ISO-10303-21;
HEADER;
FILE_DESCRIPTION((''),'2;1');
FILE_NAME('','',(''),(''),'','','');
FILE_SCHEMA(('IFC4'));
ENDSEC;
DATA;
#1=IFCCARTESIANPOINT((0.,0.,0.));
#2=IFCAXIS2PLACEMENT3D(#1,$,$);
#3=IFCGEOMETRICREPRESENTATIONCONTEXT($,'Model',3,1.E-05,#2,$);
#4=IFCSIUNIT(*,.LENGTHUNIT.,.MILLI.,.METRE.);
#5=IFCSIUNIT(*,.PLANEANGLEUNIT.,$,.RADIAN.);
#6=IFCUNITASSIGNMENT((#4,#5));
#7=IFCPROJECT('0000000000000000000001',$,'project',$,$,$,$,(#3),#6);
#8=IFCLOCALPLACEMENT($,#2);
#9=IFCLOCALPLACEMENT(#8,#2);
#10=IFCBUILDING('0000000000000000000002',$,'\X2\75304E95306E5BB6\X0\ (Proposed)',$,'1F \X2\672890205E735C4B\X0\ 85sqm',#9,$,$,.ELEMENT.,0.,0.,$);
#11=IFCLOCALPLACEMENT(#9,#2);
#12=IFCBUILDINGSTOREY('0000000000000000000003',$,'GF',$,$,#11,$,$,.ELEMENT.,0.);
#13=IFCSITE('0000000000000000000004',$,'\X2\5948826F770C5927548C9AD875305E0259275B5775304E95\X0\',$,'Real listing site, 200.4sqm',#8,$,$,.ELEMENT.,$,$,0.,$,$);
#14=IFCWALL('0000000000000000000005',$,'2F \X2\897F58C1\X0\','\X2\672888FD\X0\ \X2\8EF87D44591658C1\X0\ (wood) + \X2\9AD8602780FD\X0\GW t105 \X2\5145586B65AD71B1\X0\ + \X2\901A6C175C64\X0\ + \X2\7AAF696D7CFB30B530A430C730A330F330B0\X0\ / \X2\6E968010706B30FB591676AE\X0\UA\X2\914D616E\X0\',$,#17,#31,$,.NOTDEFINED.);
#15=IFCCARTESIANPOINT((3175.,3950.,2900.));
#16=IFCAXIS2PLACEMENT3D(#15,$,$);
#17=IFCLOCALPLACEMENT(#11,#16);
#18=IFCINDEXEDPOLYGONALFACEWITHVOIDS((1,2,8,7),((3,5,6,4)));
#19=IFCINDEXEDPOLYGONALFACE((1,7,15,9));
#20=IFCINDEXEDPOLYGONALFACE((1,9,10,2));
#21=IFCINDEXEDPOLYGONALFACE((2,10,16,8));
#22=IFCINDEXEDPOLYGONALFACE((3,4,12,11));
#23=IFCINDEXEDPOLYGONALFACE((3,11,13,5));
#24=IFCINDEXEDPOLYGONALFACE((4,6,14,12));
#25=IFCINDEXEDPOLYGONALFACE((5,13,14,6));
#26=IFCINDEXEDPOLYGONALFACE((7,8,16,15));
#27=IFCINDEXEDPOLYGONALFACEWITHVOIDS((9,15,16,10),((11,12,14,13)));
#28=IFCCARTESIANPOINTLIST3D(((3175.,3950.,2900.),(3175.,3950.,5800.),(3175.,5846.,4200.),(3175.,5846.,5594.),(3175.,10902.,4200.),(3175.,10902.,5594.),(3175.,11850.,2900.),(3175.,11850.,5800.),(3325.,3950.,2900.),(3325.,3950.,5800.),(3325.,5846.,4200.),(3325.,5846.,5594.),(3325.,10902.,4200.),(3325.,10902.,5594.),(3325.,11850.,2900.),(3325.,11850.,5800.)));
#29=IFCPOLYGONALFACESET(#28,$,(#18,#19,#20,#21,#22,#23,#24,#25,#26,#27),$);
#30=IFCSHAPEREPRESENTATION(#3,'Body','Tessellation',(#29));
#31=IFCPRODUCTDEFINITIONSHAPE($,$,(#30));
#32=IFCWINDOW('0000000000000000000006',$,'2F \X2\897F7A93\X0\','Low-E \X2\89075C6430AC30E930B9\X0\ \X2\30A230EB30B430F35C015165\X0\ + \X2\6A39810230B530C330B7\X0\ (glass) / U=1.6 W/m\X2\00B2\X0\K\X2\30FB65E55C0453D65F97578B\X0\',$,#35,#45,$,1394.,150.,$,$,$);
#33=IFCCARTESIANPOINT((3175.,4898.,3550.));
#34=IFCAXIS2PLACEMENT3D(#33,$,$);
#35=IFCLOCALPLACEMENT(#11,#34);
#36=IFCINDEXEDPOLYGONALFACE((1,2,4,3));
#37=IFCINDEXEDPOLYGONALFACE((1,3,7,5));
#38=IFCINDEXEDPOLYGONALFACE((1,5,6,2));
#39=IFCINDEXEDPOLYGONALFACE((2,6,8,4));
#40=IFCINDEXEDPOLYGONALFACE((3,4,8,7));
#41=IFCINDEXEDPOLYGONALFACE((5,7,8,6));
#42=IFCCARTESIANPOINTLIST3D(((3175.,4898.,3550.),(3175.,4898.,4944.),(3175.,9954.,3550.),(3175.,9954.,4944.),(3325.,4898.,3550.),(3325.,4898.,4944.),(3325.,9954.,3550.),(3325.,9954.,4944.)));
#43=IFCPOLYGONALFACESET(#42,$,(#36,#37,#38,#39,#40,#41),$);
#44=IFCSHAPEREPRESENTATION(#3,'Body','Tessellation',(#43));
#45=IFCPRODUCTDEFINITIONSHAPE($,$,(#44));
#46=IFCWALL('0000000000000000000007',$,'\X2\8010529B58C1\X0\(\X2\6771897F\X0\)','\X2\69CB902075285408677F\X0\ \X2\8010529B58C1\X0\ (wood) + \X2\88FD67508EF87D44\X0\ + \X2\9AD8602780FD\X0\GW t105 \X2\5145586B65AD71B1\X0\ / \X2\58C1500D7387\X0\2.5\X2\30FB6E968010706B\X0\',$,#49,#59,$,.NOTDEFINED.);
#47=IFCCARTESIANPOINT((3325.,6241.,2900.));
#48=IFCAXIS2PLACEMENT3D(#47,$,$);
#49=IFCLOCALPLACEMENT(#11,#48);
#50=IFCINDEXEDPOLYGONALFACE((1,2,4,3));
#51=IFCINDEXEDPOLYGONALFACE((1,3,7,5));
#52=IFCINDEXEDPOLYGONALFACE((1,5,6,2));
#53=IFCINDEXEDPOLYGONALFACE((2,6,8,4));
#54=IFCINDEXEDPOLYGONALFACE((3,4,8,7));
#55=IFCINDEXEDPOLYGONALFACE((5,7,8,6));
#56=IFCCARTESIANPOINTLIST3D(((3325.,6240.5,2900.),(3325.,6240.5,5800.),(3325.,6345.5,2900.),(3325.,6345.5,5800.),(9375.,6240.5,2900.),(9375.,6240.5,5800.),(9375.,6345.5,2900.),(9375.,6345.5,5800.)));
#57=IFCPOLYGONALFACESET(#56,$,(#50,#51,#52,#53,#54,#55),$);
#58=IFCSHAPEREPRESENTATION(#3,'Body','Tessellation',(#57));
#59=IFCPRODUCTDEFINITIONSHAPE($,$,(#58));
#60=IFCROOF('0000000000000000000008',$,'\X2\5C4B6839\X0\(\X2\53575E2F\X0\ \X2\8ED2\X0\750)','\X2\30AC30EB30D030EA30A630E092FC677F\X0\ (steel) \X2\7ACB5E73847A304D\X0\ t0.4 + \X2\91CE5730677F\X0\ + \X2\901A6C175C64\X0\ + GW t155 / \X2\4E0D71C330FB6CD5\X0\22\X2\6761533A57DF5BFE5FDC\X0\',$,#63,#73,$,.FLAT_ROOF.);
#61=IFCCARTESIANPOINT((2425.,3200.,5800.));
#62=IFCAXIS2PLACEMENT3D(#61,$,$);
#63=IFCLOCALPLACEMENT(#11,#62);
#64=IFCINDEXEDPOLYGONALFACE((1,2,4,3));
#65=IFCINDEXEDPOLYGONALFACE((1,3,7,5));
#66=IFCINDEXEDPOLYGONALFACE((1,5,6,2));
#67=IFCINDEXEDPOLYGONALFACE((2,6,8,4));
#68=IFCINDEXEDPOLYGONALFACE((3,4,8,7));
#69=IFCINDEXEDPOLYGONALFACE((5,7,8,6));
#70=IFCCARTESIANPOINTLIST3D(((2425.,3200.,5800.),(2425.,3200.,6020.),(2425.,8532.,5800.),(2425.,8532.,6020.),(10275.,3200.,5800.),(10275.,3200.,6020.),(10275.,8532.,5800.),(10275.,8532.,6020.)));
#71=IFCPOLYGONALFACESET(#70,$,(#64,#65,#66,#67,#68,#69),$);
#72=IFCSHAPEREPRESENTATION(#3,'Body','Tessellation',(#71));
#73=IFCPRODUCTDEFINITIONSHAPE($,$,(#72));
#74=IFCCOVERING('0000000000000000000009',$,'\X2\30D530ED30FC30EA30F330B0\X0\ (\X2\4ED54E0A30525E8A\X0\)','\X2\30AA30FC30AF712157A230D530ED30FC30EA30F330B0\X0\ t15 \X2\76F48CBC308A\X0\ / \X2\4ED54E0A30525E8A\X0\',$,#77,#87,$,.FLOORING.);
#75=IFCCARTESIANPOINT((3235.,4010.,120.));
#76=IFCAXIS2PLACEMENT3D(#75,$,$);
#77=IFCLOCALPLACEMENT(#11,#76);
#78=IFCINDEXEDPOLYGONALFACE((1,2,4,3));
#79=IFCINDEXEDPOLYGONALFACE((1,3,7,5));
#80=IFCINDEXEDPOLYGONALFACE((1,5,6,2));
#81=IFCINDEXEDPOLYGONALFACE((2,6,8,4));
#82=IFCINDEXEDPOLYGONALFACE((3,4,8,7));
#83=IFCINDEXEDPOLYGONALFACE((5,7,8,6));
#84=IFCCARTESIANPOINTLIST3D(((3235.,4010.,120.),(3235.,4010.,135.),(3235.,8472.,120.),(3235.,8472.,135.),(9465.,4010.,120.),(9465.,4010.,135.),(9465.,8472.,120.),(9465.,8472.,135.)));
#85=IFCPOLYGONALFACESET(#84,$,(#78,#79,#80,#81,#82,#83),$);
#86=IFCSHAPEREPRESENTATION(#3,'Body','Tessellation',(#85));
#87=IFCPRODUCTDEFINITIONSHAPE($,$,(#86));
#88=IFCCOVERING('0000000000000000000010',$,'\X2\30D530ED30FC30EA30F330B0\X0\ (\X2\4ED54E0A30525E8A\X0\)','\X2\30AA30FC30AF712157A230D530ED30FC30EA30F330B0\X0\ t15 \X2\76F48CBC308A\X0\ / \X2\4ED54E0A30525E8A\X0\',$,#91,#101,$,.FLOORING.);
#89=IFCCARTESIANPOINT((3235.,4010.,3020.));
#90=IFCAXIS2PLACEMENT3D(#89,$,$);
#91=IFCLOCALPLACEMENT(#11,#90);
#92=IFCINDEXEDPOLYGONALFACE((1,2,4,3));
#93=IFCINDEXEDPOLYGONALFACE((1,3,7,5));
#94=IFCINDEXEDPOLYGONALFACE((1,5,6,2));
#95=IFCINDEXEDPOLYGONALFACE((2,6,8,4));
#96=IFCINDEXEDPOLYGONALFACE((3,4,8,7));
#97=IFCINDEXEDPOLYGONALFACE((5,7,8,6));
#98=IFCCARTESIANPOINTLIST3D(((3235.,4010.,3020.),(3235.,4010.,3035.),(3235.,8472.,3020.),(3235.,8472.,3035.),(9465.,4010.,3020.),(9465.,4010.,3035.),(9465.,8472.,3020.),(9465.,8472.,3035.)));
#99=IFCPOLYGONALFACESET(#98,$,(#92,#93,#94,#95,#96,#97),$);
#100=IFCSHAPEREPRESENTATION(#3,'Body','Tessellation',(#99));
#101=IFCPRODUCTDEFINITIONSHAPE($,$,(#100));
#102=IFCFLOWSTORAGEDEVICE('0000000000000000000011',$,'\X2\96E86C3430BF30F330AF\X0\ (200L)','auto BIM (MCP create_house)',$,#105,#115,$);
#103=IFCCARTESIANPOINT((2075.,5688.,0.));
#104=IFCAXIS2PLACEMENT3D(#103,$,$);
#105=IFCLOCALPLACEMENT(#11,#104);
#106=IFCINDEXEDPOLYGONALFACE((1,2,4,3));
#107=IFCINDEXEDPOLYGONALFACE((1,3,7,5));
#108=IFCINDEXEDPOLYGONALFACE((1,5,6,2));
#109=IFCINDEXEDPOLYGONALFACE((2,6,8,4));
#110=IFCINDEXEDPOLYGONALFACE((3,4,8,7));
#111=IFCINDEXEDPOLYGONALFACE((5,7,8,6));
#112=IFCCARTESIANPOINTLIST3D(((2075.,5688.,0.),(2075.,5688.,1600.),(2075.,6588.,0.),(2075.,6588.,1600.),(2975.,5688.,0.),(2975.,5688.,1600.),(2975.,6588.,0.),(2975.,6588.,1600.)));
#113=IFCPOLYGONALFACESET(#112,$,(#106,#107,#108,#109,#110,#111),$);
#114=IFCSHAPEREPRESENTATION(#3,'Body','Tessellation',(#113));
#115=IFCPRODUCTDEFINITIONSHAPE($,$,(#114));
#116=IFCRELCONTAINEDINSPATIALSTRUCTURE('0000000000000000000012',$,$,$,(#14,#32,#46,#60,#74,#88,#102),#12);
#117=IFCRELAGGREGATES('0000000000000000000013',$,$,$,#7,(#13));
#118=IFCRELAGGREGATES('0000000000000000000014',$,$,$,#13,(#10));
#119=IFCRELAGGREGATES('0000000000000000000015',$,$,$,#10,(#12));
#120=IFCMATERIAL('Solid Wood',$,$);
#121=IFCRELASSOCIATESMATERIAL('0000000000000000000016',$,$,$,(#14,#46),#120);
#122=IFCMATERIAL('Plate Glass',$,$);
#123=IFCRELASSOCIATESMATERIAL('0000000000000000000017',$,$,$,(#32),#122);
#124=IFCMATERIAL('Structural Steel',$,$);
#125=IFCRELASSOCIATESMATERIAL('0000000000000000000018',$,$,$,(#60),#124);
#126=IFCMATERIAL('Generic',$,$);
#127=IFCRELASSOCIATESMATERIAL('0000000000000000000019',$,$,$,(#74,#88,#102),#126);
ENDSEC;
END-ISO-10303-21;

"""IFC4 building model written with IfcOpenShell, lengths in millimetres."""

from ifc_helpers import new_model, si_unit, frame, frame_2d, origin, place, context, project, spatial, rectangle, extrude, material, element, fill, save


model = new_model("IFC4")

# Units and contexts
model_context = context("Model", 3, precision=1e-05, world=origin())
ifc_project = project(units=[si_unit("LENGTHUNIT", "METRE", prefix="MILLI"), si_unit("PLANEANGLEUNIT", "RADIAN")], contexts=[model_context])

# Site, building, storey
site_placement = place(None, origin())
site = spatial("IfcSite", under=ifc_project, at=site_placement, Name="奈良県大和高田市大字田井", ObjectType="Real listing site, 200.4sqm", CompositionType="ELEMENT", RefElevation=0.0)
building_placement = place(site_placement, origin())
building = spatial("IfcBuilding", under=site, at=building_placement, Name="田井の家 (Proposed)", ObjectType="1F 木造平屋 85sqm", CompositionType="ELEMENT", ElevationOfRefHeight=0.0, ElevationOfTerrain=0.0)
storey_placement = place(building_placement, origin())
storey = spatial("IfcBuildingStorey", under=building, at=storey_placement, Name="GF", CompositionType="ELEMENT", Elevation=0.0)

# Shared definitions
ifc_material_1 = material(Name="Solid Wood")
ifc_material_2 = material(Name="Generic")

# Shared definitions
ifc_material_3 = material(Name="Plate Glass")

# Wall, opening, window
wall_1_placement = place(storey_placement, frame((3175.0, 3950.0, 2900.0)))
wall_1 = element("IfcWall", 1, at=wall_1_placement, inside=storey, material=ifc_material_1, Name="2F 西壁", Description="木製 軸組外壁 (wood) + 高性能GW t105 充填断熱 + 通気層 + 窯業系サイディング / 準耐火・外皮UA配慮", PredefinedType="NOTDEFINED", context=model_context, shape_type="SweptSolid", body=[
    extrude(rectangle(XDim=150.0, YDim=7900.0, at=frame_2d((75.0, 3950.0))), frame((3175.0, 3950.0, 2900.0)), (0.0, 0.0, 1.0), 2900.0),
])
opening_1_placement = place(storey_placement, frame((3175.0, 4898.0, 3550.0)))
opening_1 = element("IfcOpeningElement", 2, at=opening_1_placement, cuts=wall_1, PredefinedType="NOTDEFINED", context=model_context, shape_type="SweptSolid", body=[
    extrude(rectangle(XDim=150.0, YDim=5056.0, at=frame_2d((75.0, 2528.0))), frame((3175.0, 4898.0, 3550.0)), (0.0, 0.0, 1.0), 1394.0),
])
window_1_placement = place(storey_placement, frame((3175.0, 4898.0, 3550.0)))
window_1 = element("IfcWindow", 3, at=window_1_placement, inside=storey, material=ifc_material_3, Name="2F 西窓", Description="Low-E 複層ガラス アルゴン封入 + 樹脂サッシ (glass) / U=1.6 W/m²K・日射取得型", OverallHeight=1394.0, OverallWidth=150.0, context=model_context, shape_type="SweptSolid", body=[
    extrude(rectangle(XDim=150.0, YDim=5056.0, at=frame_2d((75.0, 2528.0))), frame((3175.0, 4898.0, 3550.0)), (0.0, 0.0, 1.0), 1394.0),
])
fill(opening_1, window_1)

# Wall
wall_2_placement = place(storey_placement, frame((3325.0, 6241.0, 2900.0)))
element("IfcWall", 4, at=wall_2_placement, inside=storey, material=ifc_material_1, Name="耐力壁(東西)", Description="構造用合板 耐力壁 (wood) + 製材軸組 + 高性能GW t105 充填断熱 / 壁倍率2.5・準耐火", PredefinedType="NOTDEFINED", context=model_context, shape_type="SweptSolid", body=[
    extrude(rectangle(XDim=6050.0, YDim=105.0, at=frame_2d((3025.0, 52.0))), frame((3325.0, 6241.0, 2900.0)), (0.0, 0.0, 1.0), 2900.0),
])

# Roof
ifc_material_4 = material(Name="Structural Steel")
for number, where, name in (
    (5, (2425.0, 3200.0, 5800.0), "屋根(南帯 軒750)"),
):
    element("IfcRoof", number, at=place(storey_placement, frame(where)), inside=storey, material=ifc_material_4, Name=name, Description="ガルバリウム鋼板 (steel) 立平葺き t0.4 + 野地板 + 通気層 + GW t155 / 不燃・法22条区域対応", PredefinedType="FLAT_ROOF", context=model_context, shape_type="SweptSolid", body=[
        extrude(rectangle(XDim=7850.0, YDim=5332.0, at=frame_2d((3925.0, 2666.0))), frame((2425.0, 3200.0, 5800.0)), (0.0, 0.0, 1.0), 220.0),
    ])

# Coverings
covering_1_placement = place(storey_placement, frame((3235.0, 4010.0, 120.0)))
element("IfcCovering", 6, at=covering_1_placement, inside=storey, material=ifc_material_2, Name="フローリング (仕上げ床)", Description="オーク無垢フローリング t15 直貼り / 仕上げ床", PredefinedType="FLOORING", context=model_context, shape_type="SweptSolid", body=[
    extrude(rectangle(XDim=6230.0, YDim=4462.0, at=frame_2d((3115.0, 2231.0))), frame((3235.0, 4010.0, 120.0)), (0.0, 0.0, 1.0), 15.0),
])
covering_2_placement = place(storey_placement, frame((3235.0, 4010.0, 3020.0)))
element("IfcCovering", 7, at=covering_2_placement, inside=storey, material=ifc_material_2, Name="フローリング (仕上げ床)", Description="オーク無垢フローリング t15 直貼り / 仕上げ床", PredefinedType="FLOORING", context=model_context, shape_type="SweptSolid", body=[
    extrude(rectangle(XDim=6230.0, YDim=4462.0, at=frame_2d((3115.0, 2231.0))), frame((3235.0, 4010.0, 3020.0)), (0.0, 0.0, 1.0), 15.0),
])

# Flow storage device
flow_storage_device_placement = place(storey_placement, frame((2075.0, 5688.0, 0.0)))
element("IfcFlowStorageDevice", 8, at=flow_storage_device_placement, inside=storey, material=ifc_material_2, Name="雨水タンク (200L)", Description="auto BIM (MCP create_house)", context=model_context, shape_type="SweptSolid", body=[
    extrude(rectangle(XDim=900.0, YDim=900.0, at=frame_2d((450.0, 450.0))), frame((2075.0, 5688.0, 0.0)), (0.0, 0.0, 1.0), 1600.0),
])

save(model, "model.ifc")
